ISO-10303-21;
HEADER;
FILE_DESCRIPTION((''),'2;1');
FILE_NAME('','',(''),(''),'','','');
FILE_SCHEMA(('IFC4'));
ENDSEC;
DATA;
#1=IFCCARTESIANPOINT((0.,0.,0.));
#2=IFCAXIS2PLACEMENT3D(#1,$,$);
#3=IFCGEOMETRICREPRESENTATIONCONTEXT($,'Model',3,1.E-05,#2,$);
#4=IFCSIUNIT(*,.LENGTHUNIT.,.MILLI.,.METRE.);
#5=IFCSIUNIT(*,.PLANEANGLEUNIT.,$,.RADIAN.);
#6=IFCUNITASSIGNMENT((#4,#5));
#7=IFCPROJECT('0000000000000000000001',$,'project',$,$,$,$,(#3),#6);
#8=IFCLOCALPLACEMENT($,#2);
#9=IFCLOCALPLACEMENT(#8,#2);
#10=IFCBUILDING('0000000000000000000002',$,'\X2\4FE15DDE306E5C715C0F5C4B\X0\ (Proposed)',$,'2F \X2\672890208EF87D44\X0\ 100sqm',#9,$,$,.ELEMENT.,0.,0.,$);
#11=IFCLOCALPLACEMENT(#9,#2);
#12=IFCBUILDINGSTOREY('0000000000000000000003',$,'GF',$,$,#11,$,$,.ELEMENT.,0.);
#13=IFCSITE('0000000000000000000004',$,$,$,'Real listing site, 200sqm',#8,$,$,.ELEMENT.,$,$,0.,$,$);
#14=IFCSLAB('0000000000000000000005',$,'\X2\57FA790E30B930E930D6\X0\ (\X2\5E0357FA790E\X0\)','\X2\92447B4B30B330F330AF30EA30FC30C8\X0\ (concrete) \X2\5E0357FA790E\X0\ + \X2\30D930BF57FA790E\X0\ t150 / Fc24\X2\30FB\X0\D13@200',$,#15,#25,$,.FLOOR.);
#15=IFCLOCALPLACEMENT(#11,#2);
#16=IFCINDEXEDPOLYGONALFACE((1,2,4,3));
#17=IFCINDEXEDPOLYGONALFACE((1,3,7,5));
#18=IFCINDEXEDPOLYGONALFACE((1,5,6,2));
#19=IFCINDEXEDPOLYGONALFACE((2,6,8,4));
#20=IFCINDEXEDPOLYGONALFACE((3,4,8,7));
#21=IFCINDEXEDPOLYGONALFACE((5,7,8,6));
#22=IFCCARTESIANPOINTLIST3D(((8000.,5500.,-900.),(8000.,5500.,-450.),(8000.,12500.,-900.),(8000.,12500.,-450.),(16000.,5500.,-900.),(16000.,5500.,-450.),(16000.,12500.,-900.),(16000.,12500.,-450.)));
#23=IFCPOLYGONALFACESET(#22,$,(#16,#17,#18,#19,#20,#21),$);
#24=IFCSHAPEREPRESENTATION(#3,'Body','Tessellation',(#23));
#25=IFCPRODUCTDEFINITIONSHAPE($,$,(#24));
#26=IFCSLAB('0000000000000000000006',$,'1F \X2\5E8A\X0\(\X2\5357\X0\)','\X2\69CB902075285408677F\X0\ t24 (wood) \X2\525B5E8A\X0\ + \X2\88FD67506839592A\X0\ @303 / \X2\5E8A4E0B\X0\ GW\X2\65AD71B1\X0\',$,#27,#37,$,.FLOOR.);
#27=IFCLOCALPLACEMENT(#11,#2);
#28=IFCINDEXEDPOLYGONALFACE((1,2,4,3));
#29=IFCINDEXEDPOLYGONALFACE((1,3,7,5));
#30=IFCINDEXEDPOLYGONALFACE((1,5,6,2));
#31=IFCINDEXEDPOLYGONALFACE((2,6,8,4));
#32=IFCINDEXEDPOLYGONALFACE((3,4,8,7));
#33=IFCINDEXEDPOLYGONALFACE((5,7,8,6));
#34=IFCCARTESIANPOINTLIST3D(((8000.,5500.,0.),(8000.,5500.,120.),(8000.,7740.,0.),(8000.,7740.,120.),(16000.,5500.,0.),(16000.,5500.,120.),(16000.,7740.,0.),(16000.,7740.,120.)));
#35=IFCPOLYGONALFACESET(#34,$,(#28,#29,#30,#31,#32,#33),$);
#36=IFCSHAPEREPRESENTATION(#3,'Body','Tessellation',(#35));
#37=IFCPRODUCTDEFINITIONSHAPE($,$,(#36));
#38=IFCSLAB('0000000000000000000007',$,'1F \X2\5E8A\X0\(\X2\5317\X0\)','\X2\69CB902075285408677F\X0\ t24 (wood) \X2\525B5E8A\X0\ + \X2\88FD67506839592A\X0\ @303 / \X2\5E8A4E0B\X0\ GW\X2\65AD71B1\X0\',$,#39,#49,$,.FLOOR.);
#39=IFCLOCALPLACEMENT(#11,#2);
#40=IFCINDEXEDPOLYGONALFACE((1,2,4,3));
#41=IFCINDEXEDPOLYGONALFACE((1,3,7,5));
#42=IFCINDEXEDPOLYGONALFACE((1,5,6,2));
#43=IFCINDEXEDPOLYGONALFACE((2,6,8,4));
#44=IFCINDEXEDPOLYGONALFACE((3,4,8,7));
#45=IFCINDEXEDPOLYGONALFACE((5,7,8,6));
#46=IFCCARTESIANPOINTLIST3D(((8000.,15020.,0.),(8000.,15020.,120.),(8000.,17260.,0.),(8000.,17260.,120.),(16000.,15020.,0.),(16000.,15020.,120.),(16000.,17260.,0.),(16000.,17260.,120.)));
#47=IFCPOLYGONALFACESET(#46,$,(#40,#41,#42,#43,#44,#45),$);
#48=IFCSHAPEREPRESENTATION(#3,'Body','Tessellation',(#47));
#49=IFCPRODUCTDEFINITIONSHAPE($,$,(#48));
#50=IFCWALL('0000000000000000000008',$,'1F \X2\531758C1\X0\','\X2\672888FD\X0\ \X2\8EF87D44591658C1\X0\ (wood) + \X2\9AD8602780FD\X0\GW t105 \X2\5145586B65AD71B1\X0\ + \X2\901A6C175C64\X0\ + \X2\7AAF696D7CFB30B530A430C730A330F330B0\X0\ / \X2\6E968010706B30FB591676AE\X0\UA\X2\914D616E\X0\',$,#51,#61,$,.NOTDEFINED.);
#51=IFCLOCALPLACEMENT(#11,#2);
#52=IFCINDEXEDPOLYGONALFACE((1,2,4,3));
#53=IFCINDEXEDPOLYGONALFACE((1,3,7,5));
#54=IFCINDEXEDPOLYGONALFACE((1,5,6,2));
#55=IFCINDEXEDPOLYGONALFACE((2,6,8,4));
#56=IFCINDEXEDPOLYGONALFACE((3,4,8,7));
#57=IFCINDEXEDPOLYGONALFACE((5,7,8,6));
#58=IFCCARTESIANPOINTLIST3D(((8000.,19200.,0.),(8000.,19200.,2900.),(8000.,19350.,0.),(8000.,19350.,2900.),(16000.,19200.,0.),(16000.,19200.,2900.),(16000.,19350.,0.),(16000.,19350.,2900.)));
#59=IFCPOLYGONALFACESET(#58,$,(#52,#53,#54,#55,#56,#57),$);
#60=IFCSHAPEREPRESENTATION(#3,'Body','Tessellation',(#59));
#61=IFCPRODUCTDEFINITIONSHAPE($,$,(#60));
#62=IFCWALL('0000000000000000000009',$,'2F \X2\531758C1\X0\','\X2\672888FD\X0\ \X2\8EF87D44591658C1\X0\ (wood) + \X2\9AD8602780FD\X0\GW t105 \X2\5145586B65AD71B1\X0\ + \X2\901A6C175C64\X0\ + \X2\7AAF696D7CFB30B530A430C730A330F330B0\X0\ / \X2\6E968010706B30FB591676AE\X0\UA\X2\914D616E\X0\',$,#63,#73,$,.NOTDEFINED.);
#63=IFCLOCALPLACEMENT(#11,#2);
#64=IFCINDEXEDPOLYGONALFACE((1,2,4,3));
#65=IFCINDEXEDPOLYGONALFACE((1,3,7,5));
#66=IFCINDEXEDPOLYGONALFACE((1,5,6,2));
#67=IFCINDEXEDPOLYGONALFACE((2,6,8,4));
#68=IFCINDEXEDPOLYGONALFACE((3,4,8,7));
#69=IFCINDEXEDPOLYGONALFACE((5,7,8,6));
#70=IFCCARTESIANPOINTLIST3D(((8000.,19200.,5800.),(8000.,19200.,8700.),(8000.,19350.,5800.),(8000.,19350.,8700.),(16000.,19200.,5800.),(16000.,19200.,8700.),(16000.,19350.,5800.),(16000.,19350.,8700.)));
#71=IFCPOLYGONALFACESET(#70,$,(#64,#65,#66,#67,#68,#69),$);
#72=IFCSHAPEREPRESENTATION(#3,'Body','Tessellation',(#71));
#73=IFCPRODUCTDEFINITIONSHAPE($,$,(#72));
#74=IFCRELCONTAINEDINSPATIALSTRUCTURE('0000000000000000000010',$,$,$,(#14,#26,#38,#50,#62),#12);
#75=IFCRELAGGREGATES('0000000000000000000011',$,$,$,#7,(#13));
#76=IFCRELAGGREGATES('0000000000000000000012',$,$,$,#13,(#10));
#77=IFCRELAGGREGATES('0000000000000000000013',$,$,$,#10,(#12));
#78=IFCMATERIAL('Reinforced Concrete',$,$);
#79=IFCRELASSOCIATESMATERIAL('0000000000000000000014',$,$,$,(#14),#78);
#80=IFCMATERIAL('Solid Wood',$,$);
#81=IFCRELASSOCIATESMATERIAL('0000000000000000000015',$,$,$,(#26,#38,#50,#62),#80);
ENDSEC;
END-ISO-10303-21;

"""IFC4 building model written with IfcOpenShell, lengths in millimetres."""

from ifc_helpers import new_model, si_unit, frame, frame_2d, origin, place, context, project, spatial, rectangle, extrude, material, element, save


model = new_model("IFC4")

# Units and contexts
model_context = context("Model", 3, precision=1e-05, world=origin())
ifc_project = project(units=[si_unit("LENGTHUNIT", "METRE", prefix="MILLI"), si_unit("PLANEANGLEUNIT", "RADIAN")], contexts=[model_context])

# Site, building, storey
site_placement = place(None, origin())
site = spatial("IfcSite", under=ifc_project, at=site_placement, ObjectType="Real listing site, 200sqm", CompositionType="ELEMENT", RefElevation=0.0)
building_placement = place(site_placement, origin())
building = spatial("IfcBuilding", under=site, at=building_placement, Name="信州の山小屋 (Proposed)", ObjectType="2F 木造軸組 100sqm", CompositionType="ELEMENT", ElevationOfRefHeight=0.0, ElevationOfTerrain=0.0)
storey_placement = place(building_placement, origin())
storey = spatial("IfcBuildingStorey", under=building, at=storey_placement, Name="GF", CompositionType="ELEMENT", Elevation=0.0)

# Slabs
ifc_material_1 = material(Name="Reinforced Concrete")
slab_1_placement = place(storey_placement, frame((4000.0, 2750.0, -450.0)))
element("IfcSlab", 1, at=slab_1_placement, inside=storey, material=ifc_material_1, Name="基礎スラブ (布基礎)", Description="鉄筋コンクリート (concrete) 布基礎 + ベタ基礎 t150 / Fc24・D13@200", PredefinedType="FLOOR", context=model_context, shape_type="SweptSolid", body=[
    extrude(rectangle(XDim=8000.0, YDim=7000.0, at=frame_2d((4000.0, 3500.0))), frame((4000.0, 2750.0, -450.0)), (0.0, 0.0, 1.0), 450.0),
])
ifc_material_2 = material(Name="Solid Wood")
slab_2_placement = place(storey_placement, frame((4000.0, 2750.0, 0.0)))
element("IfcSlab", 2, at=slab_2_placement, inside=storey, material=ifc_material_2, Name="1F 床(南)", Description="構造用合板 t24 (wood) 剛床 + 製材根太 @303 / 床下 GW断熱", PredefinedType="FLOOR", context=model_context, shape_type="SweptSolid", body=[
    extrude(rectangle(XDim=8000.0, YDim=2240.0, at=frame_2d((4000.0, 1120.0))), frame((4000.0, 2750.0, 0.0)), (0.0, 0.0, 1.0), 120.0),
])
slab_3_placement = place(storey_placement, frame((4000.0, 7510.0, 0.0)))
element("IfcSlab", 3, at=slab_3_placement, inside=storey, material=ifc_material_2, Name="1F 床(北)", Description="構造用合板 t24 (wood) 剛床 + 製材根太 @303 / 床下 GW断熱", PredefinedType="FLOOR", context=model_context, shape_type="SweptSolid", body=[
    extrude(rectangle(XDim=8000.0, YDim=2240.0, at=frame_2d((4000.0, 1120.0))), frame((4000.0, 7510.0, 0.0)), (0.0, 0.0, 1.0), 120.0),
])

# Wall
wall_1_placement = place(storey_placement, frame((4000.0, 9600.0, 0.0)))
element("IfcWall", 4, at=wall_1_placement, inside=storey, material=ifc_material_2, Name="1F 北壁", Description="木製 軸組外壁 (wood) + 高性能GW t105 充填断熱 + 通気層 + 窯業系サイディング / 準耐火・外皮UA配慮", PredefinedType="NOTDEFINED", context=model_context, shape_type="SweptSolid", body=[
    extrude(rectangle(XDim=8000.0, YDim=150.0, at=frame_2d((4000.0, 75.0))), frame((4000.0, 9600.0, 0.0)), (0.0, 0.0, 1.0), 2900.0),
])

# Wall
wall_2_placement = place(storey_placement, frame((4000.0, 9600.0, 2900.0)))
element("IfcWall", 5, at=wall_2_placement, inside=storey, material=ifc_material_2, Name="2F 北壁", Description="木製 軸組外壁 (wood) + 高性能GW t105 充填断熱 + 通気層 + 窯業系サイディング / 準耐火・外皮UA配慮", PredefinedType="NOTDEFINED", context=model_context, shape_type="SweptSolid", body=[
    extrude(rectangle(XDim=8000.0, YDim=150.0, at=frame_2d((4000.0, 75.0))), frame((4000.0, 9600.0, 2900.0)), (0.0, 0.0, 1.0), 2900.0),
])

save(model, "model.ifc")
